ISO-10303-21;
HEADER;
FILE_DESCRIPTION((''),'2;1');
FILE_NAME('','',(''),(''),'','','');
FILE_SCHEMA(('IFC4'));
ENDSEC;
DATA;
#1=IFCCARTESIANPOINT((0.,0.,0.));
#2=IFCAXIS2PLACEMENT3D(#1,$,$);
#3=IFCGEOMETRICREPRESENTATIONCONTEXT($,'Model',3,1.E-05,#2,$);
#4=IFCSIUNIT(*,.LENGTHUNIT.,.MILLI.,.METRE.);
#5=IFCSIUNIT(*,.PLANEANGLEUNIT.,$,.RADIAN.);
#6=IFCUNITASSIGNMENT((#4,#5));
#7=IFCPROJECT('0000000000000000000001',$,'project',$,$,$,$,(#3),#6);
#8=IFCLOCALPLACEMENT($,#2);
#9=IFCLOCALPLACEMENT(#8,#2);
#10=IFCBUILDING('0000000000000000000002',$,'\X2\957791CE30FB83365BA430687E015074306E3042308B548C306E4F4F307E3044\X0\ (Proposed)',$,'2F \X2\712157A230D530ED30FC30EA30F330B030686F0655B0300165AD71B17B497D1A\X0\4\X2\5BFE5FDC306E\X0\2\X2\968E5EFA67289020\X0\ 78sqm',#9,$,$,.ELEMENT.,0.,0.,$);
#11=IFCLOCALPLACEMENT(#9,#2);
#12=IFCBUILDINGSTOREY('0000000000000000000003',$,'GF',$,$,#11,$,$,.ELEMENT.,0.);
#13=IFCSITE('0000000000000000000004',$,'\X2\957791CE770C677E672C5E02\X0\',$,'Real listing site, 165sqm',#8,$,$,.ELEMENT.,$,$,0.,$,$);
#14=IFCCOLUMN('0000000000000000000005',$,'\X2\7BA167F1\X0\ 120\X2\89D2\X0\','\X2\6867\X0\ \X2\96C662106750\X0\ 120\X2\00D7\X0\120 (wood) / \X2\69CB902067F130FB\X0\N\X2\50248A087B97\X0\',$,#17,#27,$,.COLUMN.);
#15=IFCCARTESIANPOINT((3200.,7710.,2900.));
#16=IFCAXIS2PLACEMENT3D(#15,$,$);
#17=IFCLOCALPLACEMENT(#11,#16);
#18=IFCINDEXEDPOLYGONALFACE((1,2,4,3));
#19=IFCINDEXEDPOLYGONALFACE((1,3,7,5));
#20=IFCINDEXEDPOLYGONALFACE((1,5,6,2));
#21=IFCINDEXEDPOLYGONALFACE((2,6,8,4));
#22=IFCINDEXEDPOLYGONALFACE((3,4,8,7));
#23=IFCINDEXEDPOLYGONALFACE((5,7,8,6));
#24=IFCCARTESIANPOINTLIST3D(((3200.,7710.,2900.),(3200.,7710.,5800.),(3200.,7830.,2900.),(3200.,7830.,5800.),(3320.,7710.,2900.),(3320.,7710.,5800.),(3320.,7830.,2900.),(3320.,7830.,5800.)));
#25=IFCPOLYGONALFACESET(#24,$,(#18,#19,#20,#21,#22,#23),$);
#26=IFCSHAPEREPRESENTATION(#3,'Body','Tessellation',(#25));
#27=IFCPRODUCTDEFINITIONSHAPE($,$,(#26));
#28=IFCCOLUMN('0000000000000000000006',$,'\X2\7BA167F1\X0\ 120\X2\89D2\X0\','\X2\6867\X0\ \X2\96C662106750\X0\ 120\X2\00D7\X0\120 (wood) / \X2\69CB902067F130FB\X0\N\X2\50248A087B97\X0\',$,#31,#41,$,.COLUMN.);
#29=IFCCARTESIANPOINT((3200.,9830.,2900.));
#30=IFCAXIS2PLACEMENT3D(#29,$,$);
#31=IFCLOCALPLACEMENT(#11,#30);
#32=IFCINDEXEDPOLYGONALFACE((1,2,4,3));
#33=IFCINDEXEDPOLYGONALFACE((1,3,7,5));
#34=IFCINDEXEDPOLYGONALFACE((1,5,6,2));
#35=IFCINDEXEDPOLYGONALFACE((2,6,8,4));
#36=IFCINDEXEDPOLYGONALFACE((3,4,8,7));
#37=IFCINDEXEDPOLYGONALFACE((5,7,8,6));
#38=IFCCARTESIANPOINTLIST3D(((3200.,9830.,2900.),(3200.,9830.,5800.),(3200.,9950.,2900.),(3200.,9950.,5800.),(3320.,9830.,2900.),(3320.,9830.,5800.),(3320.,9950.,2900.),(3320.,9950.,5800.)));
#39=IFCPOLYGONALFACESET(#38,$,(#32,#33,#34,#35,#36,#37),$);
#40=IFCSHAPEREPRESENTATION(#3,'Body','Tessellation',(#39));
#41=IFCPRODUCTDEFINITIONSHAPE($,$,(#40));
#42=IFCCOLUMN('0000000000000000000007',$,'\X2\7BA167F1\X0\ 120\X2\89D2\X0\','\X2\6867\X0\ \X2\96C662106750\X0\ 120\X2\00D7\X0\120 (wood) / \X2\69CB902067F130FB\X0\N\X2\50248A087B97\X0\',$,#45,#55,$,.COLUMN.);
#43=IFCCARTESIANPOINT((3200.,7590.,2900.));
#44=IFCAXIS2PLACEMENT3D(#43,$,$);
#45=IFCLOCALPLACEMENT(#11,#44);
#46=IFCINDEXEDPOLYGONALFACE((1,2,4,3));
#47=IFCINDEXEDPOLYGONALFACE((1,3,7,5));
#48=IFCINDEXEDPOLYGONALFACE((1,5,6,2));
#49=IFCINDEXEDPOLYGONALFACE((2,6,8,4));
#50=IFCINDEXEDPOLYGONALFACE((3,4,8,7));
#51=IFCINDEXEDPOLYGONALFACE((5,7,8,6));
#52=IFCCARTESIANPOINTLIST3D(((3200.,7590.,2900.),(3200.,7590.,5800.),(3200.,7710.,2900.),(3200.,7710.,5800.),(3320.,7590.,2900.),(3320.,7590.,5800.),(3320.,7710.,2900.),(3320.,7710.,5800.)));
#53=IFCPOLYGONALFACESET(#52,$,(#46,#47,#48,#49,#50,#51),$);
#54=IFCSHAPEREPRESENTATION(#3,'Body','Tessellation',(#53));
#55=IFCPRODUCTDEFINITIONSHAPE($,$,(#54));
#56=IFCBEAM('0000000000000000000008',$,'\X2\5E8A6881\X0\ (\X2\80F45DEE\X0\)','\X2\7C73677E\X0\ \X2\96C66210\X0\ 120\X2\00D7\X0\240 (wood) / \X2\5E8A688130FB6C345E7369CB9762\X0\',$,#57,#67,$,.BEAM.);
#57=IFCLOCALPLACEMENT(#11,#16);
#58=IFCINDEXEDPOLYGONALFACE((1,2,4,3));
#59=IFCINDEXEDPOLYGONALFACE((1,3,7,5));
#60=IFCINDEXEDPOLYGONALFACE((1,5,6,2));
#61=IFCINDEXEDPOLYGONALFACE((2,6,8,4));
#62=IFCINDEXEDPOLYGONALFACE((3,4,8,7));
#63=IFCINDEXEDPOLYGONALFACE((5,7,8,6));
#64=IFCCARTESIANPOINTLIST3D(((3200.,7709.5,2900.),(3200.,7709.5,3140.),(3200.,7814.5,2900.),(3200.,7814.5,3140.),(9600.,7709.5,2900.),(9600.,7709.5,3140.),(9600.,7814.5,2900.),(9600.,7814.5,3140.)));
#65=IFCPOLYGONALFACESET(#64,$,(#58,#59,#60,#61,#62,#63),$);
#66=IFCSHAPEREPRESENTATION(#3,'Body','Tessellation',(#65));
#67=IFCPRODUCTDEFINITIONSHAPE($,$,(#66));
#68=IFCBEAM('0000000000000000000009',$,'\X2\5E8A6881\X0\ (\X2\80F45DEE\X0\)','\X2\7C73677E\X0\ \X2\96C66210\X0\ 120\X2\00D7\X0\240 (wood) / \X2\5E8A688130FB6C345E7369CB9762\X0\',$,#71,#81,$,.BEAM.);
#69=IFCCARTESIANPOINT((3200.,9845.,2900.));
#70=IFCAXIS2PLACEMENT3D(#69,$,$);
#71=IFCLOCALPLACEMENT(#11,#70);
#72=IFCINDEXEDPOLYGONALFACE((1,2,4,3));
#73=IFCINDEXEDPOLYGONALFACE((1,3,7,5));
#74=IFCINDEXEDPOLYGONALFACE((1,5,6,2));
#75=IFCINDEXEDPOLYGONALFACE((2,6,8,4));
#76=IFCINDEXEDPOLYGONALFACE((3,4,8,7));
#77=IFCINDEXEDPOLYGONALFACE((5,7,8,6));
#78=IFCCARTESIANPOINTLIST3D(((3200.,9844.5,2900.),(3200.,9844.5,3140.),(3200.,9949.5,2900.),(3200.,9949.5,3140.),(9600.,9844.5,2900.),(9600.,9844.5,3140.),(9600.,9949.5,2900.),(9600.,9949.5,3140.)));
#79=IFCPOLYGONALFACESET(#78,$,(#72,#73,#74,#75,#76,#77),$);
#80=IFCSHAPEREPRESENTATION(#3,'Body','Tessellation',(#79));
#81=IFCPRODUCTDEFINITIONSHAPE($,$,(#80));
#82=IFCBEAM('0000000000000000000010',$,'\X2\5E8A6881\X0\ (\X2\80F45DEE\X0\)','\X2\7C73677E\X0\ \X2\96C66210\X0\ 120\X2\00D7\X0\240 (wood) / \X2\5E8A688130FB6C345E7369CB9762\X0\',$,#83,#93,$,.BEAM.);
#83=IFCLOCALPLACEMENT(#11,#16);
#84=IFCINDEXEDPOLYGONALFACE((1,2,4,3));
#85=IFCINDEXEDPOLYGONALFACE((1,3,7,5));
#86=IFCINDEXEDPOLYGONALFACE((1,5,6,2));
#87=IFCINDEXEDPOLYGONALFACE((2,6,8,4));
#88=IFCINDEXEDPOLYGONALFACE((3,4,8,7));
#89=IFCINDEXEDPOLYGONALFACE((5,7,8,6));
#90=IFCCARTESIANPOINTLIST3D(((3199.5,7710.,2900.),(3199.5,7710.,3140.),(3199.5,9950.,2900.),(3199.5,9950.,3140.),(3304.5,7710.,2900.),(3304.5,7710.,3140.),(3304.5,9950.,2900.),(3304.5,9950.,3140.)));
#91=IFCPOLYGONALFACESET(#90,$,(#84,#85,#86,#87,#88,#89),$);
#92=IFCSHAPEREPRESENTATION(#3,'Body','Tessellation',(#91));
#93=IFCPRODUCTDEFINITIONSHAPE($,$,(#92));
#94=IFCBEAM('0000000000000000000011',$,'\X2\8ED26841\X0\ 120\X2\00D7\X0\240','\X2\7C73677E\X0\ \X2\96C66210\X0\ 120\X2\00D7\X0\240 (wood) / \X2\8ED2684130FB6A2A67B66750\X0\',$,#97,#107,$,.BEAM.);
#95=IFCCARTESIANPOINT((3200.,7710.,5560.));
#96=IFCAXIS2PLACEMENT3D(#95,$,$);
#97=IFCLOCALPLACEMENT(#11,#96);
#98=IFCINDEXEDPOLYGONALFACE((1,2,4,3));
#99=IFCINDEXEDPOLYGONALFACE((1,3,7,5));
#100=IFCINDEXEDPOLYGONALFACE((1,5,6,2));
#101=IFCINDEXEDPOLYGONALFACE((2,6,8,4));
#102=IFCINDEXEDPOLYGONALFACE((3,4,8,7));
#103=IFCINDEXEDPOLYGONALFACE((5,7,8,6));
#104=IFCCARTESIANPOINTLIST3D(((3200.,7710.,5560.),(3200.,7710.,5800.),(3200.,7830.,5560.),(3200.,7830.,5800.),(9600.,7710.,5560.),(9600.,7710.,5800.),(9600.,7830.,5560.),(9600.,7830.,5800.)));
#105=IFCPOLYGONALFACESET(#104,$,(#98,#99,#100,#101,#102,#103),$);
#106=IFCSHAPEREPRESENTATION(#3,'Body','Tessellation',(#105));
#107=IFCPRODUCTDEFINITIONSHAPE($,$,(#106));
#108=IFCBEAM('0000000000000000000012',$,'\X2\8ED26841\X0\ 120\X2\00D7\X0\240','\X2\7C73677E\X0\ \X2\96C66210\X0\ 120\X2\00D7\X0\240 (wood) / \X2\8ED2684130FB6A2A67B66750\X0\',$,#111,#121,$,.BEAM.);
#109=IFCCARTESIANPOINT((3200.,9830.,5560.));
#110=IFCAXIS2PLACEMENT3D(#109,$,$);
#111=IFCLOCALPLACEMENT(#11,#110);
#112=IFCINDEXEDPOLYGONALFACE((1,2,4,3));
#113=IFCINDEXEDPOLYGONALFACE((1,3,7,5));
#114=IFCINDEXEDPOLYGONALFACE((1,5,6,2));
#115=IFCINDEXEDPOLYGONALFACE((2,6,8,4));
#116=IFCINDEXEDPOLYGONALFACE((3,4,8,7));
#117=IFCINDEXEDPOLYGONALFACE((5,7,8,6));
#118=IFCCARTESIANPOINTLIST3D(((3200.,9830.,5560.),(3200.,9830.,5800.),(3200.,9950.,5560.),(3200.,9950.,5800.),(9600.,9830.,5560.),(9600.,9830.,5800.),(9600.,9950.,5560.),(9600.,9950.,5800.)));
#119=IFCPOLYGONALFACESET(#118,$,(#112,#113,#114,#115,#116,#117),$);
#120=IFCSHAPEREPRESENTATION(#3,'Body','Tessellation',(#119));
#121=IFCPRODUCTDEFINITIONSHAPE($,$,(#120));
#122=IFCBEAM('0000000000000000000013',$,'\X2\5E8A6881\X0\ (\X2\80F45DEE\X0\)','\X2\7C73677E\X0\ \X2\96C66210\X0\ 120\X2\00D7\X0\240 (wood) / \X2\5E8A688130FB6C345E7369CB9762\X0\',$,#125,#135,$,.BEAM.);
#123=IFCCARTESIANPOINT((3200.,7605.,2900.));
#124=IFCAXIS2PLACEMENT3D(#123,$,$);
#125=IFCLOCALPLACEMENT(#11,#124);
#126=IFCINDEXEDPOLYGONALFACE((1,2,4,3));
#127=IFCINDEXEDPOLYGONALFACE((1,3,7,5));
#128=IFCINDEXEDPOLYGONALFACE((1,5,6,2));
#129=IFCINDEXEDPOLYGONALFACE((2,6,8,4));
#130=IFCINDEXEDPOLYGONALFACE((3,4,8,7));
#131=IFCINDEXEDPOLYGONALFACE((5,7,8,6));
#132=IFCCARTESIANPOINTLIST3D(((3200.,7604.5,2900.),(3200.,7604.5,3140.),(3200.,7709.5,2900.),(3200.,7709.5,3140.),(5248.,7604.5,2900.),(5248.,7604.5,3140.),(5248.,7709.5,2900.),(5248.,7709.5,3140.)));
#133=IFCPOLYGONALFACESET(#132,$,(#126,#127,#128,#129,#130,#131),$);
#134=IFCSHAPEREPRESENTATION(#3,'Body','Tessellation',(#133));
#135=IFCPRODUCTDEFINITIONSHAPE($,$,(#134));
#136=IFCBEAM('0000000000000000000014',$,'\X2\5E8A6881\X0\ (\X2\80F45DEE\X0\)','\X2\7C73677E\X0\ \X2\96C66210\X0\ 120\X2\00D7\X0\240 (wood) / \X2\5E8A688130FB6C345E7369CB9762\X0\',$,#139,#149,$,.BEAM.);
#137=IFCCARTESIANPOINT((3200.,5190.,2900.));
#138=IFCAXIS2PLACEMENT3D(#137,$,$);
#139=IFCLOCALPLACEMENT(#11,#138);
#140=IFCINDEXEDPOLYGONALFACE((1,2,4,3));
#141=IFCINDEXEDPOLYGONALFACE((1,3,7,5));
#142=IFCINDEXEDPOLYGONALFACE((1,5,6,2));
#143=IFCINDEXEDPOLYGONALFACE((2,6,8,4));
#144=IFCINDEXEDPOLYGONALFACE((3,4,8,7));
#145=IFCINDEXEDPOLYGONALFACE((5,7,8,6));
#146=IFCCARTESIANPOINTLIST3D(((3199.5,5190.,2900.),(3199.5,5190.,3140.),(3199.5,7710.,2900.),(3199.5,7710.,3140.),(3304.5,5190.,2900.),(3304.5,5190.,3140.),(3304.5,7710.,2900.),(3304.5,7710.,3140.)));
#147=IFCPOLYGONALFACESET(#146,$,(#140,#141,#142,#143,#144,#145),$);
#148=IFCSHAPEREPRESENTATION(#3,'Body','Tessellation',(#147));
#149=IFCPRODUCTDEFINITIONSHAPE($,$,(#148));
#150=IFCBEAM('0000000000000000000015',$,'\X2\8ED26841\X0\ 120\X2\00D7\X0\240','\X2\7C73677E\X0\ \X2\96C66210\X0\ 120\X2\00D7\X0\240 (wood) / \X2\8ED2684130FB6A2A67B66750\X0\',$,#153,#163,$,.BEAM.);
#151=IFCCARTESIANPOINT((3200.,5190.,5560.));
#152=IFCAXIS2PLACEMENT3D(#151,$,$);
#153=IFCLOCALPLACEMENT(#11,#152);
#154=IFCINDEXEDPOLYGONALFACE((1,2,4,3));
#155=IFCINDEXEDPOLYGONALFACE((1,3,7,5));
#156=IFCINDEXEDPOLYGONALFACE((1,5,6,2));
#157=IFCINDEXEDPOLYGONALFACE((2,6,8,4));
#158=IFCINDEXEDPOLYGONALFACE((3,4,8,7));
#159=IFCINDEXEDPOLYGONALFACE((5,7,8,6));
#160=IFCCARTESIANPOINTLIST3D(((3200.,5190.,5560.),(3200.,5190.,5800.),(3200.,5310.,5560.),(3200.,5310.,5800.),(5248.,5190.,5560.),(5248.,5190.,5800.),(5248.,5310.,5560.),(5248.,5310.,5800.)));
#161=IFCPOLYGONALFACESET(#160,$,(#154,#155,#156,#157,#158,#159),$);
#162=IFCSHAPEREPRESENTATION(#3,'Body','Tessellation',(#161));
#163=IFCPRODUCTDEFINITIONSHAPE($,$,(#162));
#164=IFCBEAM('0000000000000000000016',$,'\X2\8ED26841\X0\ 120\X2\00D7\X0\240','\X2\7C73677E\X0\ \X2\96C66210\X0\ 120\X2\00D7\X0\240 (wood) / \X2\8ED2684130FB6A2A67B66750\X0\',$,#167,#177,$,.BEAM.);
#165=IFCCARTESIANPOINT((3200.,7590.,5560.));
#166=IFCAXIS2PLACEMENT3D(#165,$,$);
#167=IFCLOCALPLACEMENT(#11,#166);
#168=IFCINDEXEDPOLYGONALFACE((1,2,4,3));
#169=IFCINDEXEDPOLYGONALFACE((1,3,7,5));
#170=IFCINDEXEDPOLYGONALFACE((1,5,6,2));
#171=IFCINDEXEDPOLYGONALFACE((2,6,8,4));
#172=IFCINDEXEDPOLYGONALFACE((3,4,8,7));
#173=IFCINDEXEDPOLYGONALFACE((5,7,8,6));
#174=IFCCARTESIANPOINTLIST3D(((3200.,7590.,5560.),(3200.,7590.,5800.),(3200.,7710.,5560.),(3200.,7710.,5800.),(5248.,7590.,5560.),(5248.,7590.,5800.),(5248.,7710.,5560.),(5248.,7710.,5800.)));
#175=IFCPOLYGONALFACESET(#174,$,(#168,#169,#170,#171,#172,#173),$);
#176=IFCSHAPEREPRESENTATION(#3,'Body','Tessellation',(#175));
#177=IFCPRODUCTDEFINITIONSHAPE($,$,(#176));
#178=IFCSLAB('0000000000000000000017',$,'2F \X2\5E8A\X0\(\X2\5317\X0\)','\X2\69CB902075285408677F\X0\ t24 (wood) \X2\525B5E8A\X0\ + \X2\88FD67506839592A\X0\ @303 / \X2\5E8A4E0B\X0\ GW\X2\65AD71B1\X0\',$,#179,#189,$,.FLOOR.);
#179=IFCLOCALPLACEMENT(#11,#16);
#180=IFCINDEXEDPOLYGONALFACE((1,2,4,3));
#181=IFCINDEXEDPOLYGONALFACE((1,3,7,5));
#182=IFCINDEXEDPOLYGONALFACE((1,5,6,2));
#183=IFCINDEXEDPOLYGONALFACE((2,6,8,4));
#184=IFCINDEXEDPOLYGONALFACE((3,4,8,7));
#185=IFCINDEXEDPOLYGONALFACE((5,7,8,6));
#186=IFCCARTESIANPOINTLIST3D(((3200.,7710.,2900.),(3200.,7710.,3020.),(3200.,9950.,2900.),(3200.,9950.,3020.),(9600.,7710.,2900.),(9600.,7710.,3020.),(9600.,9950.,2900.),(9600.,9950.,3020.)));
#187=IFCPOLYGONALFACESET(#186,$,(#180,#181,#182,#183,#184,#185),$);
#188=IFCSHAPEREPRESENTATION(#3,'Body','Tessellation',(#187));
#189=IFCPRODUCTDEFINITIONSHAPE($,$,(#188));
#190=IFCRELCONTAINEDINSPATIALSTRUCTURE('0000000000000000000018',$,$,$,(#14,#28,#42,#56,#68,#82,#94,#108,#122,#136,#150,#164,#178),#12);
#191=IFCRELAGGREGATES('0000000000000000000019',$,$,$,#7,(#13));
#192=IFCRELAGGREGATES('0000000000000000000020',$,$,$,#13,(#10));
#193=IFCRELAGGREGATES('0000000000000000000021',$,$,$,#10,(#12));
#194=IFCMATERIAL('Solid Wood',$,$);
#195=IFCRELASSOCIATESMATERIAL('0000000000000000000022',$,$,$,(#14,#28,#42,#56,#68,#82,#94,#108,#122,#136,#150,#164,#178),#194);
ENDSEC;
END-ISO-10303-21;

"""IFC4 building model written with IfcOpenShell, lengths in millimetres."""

from ifc_helpers import new_model, si_unit, frame, frame_2d, origin, place, context, project, spatial, rectangle, extrude, material, element, save


model = new_model("IFC4")

# Units and contexts
model_context = context("Model", 3, precision=1e-05, world=origin())
ifc_project = project(units=[si_unit("LENGTHUNIT", "METRE", prefix="MILLI"), si_unit("PLANEANGLEUNIT", "RADIAN")], contexts=[model_context])

# Site, building, storey
site_placement = place(None, origin())
site = spatial("IfcSite", under=ifc_project, at=site_placement, Name="長野県松本市", ObjectType="Real listing site, 165sqm", CompositionType="ELEMENT", RefElevation=0.0)
building_placement = place(site_placement, origin())
building = spatial("IfcBuilding", under=site, at=building_placement, Name="長野・茶室と縁側のある和の住まい (Proposed)", ObjectType="2F 無垢フローリングと漆喰、断熱等級4対応の2階建木造 78sqm", CompositionType="ELEMENT", ElevationOfRefHeight=0.0, ElevationOfTerrain=0.0)
storey_placement = place(building_placement, origin())
storey = spatial("IfcBuildingStorey", under=building, at=storey_placement, Name="GF", CompositionType="ELEMENT", Elevation=0.0)

# Columns
ifc_material_1 = material(Name="Solid Wood")
column_1_placement = place(storey_placement, frame((3200.0, 7710.0, 2900.0)))
element("IfcColumn", 1, at=column_1_placement, inside=storey, material=ifc_material_1, Name="管柱 120角", Description="桧 集成材 120×120 (wood) / 構造柱・N値計算", PredefinedType="COLUMN", context=model_context, shape_type="SweptSolid", body=[
    extrude(rectangle(XDim=120.0, YDim=120.0, at=frame_2d((60.0, 60.0))), frame((3200.0, 7710.0, 2900.0)), (0.0, 0.0, 1.0), 2900.0),
])
column_2_placement = place(storey_placement, frame((3200.0, 9830.0, 2900.0)))
element("IfcColumn", 2, at=column_2_placement, inside=storey, material=ifc_material_1, Name="管柱 120角", Description="桧 集成材 120×120 (wood) / 構造柱・N値計算", PredefinedType="COLUMN", context=model_context, shape_type="SweptSolid", body=[
    extrude(rectangle(XDim=120.0, YDim=120.0, at=frame_2d((60.0, 60.0))), frame((3200.0, 9830.0, 2900.0)), (0.0, 0.0, 1.0), 2900.0),
])
column_3_placement = place(storey_placement, frame((3200.0, 7590.0, 2900.0)))
element("IfcColumn", 3, at=column_3_placement, inside=storey, material=ifc_material_1, Name="管柱 120角", Description="桧 集成材 120×120 (wood) / 構造柱・N値計算", PredefinedType="COLUMN", context=model_context, shape_type="SweptSolid", body=[
    extrude(rectangle(XDim=120.0, YDim=120.0, at=frame_2d((60.0, 60.0))), frame((3200.0, 7590.0, 2900.0)), (0.0, 0.0, 1.0), 2900.0),
])

# Beams
beam_1_placement = place(storey_placement, frame((3200.0, 7710.0, 2900.0)))
element("IfcBeam", 4, at=beam_1_placement, inside=storey, material=ifc_material_1, Name="床梁 (胴差)", Description="米松 集成 120×240 (wood) / 床梁・水平構面", PredefinedType="BEAM", context=model_context, shape_type="SweptSolid", body=[
    extrude(rectangle(XDim=6400.0, YDim=105.0, at=frame_2d((3200.0, 52.0))), frame((3200.0, 7710.0, 2900.0)), (0.0, 0.0, 1.0), 240.0),
])
beam_2_placement = place(storey_placement, frame((3200.0, 9845.0, 2900.0)))
element("IfcBeam", 5, at=beam_2_placement, inside=storey, material=ifc_material_1, Name="床梁 (胴差)", Description="米松 集成 120×240 (wood) / 床梁・水平構面", PredefinedType="BEAM", context=model_context, shape_type="SweptSolid", body=[
    extrude(rectangle(XDim=6400.0, YDim=105.0, at=frame_2d((3200.0, 52.0))), frame((3200.0, 9845.0, 2900.0)), (0.0, 0.0, 1.0), 240.0),
])
beam_3_placement = place(storey_placement, frame((3200.0, 7710.0, 2900.0)))
element("IfcBeam", 6, at=beam_3_placement, inside=storey, material=ifc_material_1, Name="床梁 (胴差)", Description="米松 集成 120×240 (wood) / 床梁・水平構面", PredefinedType="BEAM", context=model_context, shape_type="SweptSolid", body=[
    extrude(rectangle(XDim=105.0, YDim=2240.0, at=frame_2d((52.0, 1120.0))), frame((3200.0, 7710.0, 2900.0)), (0.0, 0.0, 1.0), 240.0),
])
beam_4_placement = place(storey_placement, frame((3200.0, 7710.0, 5560.0)))
element("IfcBeam", 7, at=beam_4_placement, inside=storey, material=ifc_material_1, Name="軒桁 120×240", Description="米松 集成 120×240 (wood) / 軒桁・横架材", PredefinedType="BEAM", context=model_context, shape_type="SweptSolid", body=[
    extrude(rectangle(XDim=6400.0, YDim=120.0, at=frame_2d((3200.0, 60.0))), frame((3200.0, 7710.0, 5560.0)), (0.0, 0.0, 1.0), 240.0),
])
beam_5_placement = place(storey_placement, frame((3200.0, 9830.0, 5560.0)))
element("IfcBeam", 8, at=beam_5_placement, inside=storey, material=ifc_material_1, Name="軒桁 120×240", Description="米松 集成 120×240 (wood) / 軒桁・横架材", PredefinedType="BEAM", context=model_context, shape_type="SweptSolid", body=[
    extrude(rectangle(XDim=6400.0, YDim=120.0, at=frame_2d((3200.0, 60.0))), frame((3200.0, 9830.0, 5560.0)), (0.0, 0.0, 1.0), 240.0),
])
beam_6_placement = place(storey_placement, frame((3200.0, 7605.0, 2900.0)))
element("IfcBeam", 9, at=beam_6_placement, inside=storey, material=ifc_material_1, Name="床梁 (胴差)", Description="米松 集成 120×240 (wood) / 床梁・水平構面", PredefinedType="BEAM", context=model_context, shape_type="SweptSolid", body=[
    extrude(rectangle(XDim=2048.0, YDim=105.0, at=frame_2d((1024.0, 52.0))), frame((3200.0, 7605.0, 2900.0)), (0.0, 0.0, 1.0), 240.0),
])
beam_7_placement = place(storey_placement, frame((3200.0, 5190.0, 2900.0)))
element("IfcBeam", 10, at=beam_7_placement, inside=storey, material=ifc_material_1, Name="床梁 (胴差)", Description="米松 集成 120×240 (wood) / 床梁・水平構面", PredefinedType="BEAM", context=model_context, shape_type="SweptSolid", body=[
    extrude(rectangle(XDim=105.0, YDim=2520.0, at=frame_2d((52.0, 1260.0))), frame((3200.0, 5190.0, 2900.0)), (0.0, 0.0, 1.0), 240.0),
])
beam_8_placement = place(storey_placement, frame((3200.0, 5190.0, 5560.0)))
element("IfcBeam", 11, at=beam_8_placement, inside=storey, material=ifc_material_1, Name="軒桁 120×240", Description="米松 集成 120×240 (wood) / 軒桁・横架材", PredefinedType="BEAM", context=model_context, shape_type="SweptSolid", body=[
    extrude(rectangle(XDim=2048.0, YDim=120.0, at=frame_2d((1024.0, 60.0))), frame((3200.0, 5190.0, 5560.0)), (0.0, 0.0, 1.0), 240.0),
])
beam_9_placement = place(storey_placement, frame((3200.0, 7590.0, 5560.0)))
element("IfcBeam", 12, at=beam_9_placement, inside=storey, material=ifc_material_1, Name="軒桁 120×240", Description="米松 集成 120×240 (wood) / 軒桁・横架材", PredefinedType="BEAM", context=model_context, shape_type="SweptSolid", body=[
    extrude(rectangle(XDim=2048.0, YDim=120.0, at=frame_2d((1024.0, 60.0))), frame((3200.0, 7590.0, 5560.0)), (0.0, 0.0, 1.0), 240.0),
])

# Slab
slab_placement = place(storey_placement, frame((3200.0, 7710.0, 2900.0)))
element("IfcSlab", 13, at=slab_placement, inside=storey, material=ifc_material_1, Name="2F 床(北)", Description="構造用合板 t24 (wood) 剛床 + 製材根太 @303 / 床下 GW断熱", PredefinedType="FLOOR", context=model_context, shape_type="SweptSolid", body=[
    extrude(rectangle(XDim=6400.0, YDim=2240.0, at=frame_2d((3200.0, 1120.0))), frame((3200.0, 7710.0, 2900.0)), (0.0, 0.0, 1.0), 120.0),
])

save(model, "model.ifc")
